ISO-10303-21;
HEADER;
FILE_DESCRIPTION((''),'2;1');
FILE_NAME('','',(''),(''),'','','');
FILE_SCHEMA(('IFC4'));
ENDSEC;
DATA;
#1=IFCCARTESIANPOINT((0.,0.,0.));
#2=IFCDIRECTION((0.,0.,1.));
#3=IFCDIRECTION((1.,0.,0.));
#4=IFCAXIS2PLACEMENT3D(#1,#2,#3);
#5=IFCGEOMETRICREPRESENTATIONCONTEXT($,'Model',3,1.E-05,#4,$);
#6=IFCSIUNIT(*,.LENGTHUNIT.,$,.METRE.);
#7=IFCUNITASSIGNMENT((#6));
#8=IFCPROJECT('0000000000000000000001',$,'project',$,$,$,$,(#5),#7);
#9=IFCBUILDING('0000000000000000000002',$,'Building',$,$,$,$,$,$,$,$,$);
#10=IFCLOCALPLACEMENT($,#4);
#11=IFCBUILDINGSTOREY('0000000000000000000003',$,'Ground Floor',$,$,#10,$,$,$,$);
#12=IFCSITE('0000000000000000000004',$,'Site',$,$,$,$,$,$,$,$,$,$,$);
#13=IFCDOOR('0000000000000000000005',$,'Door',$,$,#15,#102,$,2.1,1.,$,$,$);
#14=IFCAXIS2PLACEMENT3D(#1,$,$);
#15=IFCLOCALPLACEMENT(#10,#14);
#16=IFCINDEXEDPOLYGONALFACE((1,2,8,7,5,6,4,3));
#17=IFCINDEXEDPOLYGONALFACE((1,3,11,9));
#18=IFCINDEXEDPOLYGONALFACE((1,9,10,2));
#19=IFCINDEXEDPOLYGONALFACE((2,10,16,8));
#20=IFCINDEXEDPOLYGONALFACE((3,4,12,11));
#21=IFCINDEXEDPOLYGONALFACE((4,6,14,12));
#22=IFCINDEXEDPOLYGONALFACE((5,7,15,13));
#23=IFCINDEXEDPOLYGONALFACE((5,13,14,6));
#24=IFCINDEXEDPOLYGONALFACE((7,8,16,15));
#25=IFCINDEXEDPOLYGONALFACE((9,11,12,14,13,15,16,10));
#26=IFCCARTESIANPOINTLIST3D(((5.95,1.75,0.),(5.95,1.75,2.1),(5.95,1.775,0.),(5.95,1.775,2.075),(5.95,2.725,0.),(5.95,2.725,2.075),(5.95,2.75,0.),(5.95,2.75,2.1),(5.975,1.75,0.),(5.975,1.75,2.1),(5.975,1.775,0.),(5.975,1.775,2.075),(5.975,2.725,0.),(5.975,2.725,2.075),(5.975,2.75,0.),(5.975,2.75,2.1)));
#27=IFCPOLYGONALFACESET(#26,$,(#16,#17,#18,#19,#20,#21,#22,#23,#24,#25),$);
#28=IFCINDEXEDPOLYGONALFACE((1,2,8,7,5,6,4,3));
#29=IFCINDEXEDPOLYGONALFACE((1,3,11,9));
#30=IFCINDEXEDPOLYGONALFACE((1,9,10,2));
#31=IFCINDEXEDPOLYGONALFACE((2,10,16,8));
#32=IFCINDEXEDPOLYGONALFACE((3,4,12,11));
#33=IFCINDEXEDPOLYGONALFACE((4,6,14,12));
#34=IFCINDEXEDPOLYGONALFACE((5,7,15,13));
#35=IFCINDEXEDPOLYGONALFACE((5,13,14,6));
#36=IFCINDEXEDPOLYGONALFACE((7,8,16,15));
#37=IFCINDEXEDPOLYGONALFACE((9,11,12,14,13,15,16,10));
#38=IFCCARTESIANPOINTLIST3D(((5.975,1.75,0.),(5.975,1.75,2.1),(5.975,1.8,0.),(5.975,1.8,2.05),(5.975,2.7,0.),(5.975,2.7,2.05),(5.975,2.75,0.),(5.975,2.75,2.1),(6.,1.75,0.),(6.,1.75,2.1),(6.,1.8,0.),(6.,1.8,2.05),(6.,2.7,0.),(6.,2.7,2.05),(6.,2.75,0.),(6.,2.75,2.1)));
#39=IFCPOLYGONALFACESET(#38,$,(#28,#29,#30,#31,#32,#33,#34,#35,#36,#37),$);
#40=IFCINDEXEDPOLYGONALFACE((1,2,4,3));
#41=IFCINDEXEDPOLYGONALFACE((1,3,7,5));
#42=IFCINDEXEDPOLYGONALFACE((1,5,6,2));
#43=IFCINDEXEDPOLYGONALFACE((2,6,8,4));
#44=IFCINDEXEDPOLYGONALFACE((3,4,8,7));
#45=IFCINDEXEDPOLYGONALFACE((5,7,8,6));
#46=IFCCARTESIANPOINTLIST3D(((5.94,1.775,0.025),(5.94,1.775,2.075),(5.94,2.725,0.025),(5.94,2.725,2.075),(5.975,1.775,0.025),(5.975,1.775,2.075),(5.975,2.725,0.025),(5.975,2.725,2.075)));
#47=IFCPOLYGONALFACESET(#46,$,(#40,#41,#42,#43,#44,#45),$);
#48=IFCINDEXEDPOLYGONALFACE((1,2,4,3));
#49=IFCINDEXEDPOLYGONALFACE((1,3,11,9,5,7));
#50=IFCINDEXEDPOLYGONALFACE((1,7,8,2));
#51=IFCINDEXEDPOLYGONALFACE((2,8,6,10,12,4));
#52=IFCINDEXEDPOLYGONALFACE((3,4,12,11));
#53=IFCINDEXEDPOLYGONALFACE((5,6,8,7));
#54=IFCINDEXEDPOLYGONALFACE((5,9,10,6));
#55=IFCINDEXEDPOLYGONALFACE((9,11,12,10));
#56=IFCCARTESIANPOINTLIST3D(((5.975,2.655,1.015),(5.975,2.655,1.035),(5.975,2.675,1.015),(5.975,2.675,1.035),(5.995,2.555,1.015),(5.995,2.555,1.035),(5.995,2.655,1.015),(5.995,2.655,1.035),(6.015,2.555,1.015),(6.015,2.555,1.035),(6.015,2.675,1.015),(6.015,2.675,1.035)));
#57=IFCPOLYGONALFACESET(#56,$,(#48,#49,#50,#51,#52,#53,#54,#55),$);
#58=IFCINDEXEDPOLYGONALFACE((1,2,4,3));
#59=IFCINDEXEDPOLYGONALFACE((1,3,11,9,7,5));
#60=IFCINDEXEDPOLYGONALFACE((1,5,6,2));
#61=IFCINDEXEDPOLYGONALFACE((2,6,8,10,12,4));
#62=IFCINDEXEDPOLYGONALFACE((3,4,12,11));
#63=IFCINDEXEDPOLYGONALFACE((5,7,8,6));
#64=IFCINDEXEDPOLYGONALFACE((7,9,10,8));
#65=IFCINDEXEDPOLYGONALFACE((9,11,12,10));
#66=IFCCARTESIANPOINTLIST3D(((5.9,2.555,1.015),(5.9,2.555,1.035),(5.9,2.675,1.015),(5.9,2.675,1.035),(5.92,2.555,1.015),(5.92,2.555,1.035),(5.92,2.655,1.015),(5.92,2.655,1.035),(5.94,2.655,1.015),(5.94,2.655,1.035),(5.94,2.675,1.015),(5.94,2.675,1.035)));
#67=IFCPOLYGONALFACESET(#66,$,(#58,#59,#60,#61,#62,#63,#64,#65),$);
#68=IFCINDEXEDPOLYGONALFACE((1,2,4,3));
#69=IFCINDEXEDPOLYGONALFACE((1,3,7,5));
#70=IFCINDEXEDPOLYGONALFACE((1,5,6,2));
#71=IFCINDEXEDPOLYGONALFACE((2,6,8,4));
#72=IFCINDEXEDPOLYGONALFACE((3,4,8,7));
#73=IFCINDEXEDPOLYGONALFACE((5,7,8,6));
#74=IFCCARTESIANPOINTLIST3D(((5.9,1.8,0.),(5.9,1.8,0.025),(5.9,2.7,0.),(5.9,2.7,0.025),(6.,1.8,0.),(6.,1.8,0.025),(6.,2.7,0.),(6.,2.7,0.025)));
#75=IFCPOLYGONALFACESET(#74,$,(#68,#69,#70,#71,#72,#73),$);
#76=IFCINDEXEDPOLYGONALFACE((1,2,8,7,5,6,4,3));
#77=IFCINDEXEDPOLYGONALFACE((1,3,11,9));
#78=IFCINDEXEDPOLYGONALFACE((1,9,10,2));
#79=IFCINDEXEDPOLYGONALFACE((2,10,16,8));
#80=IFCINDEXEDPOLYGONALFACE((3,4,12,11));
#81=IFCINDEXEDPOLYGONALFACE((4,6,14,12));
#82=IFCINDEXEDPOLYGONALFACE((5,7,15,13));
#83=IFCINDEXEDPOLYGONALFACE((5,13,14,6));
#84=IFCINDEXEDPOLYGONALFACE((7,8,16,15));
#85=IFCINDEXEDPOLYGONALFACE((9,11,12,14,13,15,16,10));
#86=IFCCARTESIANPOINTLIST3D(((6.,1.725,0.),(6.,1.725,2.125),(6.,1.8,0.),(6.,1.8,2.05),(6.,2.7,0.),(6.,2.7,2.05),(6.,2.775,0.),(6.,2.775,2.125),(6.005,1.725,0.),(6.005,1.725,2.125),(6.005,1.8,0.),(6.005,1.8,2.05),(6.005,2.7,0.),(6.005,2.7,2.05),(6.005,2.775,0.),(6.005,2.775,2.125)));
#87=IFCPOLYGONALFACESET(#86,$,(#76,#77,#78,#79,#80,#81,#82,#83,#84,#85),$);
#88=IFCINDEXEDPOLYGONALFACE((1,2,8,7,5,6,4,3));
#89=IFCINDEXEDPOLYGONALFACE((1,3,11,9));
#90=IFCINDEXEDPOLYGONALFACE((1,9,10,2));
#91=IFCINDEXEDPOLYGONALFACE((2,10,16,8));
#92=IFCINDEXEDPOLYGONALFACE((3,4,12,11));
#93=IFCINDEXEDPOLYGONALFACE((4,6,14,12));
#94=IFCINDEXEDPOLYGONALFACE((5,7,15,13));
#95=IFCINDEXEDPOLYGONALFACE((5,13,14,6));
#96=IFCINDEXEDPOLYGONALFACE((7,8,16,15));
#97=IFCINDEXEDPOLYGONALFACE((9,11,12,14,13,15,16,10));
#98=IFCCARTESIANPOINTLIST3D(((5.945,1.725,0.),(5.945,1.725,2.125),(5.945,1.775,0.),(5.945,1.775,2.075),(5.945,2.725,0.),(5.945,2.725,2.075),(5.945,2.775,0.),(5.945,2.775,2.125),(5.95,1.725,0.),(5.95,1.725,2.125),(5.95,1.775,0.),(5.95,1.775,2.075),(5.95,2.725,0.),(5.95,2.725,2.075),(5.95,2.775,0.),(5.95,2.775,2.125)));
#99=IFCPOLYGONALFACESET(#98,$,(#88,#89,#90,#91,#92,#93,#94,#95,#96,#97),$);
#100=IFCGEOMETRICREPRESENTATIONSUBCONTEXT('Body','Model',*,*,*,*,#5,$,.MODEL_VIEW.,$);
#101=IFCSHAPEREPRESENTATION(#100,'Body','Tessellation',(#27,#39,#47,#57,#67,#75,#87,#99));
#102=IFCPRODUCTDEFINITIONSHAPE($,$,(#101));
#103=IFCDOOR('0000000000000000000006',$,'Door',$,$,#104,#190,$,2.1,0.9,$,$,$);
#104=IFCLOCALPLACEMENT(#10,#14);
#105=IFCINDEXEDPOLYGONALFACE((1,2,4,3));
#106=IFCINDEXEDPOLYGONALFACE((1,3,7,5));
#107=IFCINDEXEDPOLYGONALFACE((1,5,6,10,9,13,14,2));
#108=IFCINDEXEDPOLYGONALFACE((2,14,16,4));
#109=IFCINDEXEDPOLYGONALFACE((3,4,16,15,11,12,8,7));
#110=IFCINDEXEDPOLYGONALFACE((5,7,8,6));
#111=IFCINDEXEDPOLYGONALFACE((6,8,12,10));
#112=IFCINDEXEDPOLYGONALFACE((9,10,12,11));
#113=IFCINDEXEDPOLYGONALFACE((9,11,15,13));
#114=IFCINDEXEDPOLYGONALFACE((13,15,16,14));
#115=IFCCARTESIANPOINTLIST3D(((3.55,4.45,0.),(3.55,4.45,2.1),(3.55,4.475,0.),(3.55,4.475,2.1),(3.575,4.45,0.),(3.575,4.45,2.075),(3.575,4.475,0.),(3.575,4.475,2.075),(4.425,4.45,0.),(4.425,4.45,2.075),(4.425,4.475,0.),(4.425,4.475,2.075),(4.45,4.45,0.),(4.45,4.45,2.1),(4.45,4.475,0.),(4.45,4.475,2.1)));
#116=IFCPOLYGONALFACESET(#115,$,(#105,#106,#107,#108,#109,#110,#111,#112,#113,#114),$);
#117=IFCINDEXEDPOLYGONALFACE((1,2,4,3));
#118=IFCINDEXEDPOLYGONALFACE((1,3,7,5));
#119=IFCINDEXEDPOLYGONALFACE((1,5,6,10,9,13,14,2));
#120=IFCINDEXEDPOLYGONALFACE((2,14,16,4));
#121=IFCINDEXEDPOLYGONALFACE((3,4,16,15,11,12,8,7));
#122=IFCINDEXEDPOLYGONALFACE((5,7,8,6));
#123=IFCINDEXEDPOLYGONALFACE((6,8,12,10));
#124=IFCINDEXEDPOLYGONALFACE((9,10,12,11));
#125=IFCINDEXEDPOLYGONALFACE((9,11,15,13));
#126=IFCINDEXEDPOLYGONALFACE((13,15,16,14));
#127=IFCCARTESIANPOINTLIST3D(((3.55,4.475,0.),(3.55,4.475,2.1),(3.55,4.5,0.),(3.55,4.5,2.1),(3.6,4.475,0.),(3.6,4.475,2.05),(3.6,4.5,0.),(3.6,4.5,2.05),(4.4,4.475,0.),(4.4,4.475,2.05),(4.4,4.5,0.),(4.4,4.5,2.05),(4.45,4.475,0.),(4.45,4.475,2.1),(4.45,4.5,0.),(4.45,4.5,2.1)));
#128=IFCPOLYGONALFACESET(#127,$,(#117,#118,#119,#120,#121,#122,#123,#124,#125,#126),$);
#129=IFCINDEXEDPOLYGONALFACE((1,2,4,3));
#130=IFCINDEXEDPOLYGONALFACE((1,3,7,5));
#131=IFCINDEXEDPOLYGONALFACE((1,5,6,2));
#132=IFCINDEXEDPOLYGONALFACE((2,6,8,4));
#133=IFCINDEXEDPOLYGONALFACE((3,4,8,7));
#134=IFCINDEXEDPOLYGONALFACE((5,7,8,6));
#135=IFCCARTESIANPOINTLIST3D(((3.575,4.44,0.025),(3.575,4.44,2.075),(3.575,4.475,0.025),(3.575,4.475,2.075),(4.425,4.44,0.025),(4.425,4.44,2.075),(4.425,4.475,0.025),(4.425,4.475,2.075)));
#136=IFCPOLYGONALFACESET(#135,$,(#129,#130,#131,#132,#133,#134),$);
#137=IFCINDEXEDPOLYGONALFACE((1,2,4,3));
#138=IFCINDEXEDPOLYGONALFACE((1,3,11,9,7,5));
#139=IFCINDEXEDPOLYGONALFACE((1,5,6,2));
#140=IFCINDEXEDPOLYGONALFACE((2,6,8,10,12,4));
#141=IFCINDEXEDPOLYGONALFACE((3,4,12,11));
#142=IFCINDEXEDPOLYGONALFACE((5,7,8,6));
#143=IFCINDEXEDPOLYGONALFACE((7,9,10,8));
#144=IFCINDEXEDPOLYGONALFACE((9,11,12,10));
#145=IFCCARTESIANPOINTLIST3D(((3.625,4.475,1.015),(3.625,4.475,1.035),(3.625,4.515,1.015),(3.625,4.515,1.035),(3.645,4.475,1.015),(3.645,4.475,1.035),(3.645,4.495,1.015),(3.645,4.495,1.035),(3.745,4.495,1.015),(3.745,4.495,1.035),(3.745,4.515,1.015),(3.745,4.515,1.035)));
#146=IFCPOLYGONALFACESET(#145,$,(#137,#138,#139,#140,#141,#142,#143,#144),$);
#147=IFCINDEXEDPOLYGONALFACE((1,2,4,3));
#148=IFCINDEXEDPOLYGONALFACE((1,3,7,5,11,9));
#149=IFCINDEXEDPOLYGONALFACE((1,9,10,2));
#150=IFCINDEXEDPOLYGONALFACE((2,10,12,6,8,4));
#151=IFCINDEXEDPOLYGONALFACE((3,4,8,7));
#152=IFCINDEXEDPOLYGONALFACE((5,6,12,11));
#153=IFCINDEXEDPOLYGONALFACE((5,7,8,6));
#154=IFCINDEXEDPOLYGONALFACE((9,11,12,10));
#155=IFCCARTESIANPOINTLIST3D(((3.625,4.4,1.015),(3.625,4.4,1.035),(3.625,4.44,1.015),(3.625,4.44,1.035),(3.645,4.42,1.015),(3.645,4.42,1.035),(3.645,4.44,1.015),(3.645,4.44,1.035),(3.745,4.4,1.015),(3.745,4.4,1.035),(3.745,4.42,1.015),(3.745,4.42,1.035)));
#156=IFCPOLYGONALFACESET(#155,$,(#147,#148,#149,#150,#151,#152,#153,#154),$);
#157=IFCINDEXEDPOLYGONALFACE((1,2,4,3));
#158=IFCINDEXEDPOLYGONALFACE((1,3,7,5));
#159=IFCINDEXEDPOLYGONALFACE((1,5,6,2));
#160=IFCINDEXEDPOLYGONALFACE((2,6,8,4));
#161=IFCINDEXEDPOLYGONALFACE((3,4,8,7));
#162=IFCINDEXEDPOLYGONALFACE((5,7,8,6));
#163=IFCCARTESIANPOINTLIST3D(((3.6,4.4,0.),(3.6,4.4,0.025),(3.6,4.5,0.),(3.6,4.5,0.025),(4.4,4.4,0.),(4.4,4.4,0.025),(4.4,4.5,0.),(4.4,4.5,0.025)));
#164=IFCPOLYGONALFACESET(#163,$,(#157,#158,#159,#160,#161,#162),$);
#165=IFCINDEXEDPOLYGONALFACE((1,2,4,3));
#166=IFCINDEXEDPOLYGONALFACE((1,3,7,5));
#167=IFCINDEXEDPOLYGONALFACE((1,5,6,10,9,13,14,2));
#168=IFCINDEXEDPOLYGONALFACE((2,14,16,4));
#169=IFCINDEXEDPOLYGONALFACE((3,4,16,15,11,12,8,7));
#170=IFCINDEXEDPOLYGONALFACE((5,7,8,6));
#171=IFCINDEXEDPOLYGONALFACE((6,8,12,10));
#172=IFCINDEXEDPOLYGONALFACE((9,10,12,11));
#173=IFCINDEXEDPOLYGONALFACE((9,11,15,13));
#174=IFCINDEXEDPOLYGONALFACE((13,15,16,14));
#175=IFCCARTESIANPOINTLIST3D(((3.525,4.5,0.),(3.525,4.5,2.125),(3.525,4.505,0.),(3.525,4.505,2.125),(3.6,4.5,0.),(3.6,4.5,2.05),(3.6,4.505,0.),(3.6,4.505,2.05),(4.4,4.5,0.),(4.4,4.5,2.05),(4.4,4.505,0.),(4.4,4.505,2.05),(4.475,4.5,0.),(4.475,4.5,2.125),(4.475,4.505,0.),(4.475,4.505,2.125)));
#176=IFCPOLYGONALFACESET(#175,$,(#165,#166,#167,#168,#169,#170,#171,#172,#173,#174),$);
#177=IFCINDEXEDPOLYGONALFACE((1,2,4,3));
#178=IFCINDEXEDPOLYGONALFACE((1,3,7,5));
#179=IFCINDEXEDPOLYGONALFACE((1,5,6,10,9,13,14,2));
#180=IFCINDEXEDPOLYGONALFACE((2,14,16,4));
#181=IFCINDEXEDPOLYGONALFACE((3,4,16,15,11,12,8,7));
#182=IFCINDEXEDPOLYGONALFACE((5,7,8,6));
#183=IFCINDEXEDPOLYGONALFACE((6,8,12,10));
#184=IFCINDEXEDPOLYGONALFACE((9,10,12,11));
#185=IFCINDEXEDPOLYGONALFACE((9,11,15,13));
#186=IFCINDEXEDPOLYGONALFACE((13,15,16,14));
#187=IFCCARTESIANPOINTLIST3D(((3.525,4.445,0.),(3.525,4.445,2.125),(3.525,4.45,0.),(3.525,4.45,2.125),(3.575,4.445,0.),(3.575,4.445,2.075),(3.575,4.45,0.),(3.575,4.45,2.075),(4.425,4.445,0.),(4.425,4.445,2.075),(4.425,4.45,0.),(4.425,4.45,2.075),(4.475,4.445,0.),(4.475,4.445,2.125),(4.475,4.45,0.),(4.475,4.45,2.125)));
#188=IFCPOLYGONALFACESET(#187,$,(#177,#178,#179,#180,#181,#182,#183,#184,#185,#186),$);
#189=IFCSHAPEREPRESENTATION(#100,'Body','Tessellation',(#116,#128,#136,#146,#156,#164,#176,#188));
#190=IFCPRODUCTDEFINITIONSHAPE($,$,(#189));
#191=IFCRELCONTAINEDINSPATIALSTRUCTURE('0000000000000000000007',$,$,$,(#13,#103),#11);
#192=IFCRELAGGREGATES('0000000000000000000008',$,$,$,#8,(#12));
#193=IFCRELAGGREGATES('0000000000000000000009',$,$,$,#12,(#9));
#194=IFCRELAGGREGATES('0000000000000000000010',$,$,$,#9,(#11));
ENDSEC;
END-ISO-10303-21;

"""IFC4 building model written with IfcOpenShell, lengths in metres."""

from ifc_helpers import new_model, si_unit, frame, origin_with_axes, place, context, subcontext, project, spatial, line, indexed_curve, outline, extrude, element, save


model = new_model("IFC4")

# Units and contexts
model_context = context("Model", 3, precision=1e-05, world=origin_with_axes())
body_context = subcontext(model_context, "Body", "Model", "MODEL_VIEW")
ifc_project = project(units=[si_unit("LENGTHUNIT", "METRE")], contexts=[model_context])

# Site, building, storey
site = spatial("IfcSite", under=ifc_project, Name="Site")
building = spatial("IfcBuilding", under=site, Name="Building")
storey_placement = place(None, origin_with_axes())
storey = spatial("IfcBuildingStorey", under=building, at=storey_placement, Name="Ground Floor")

# Doors
door_1_placement = place(storey_placement, frame((6.0, 1.75, 0.0), z_axis=(0.0, 0.0, 1.0), x_axis=(0.0, 1.0, 0.0)))
element("IfcDoor", 1, at=door_1_placement, inside=storey, Name="Door", OverallHeight=2.1, OverallWidth=1.0, context=body_context, shape_type="SweptSolid", body=[
    extrude(outline(indexed_curve([(0.0, 0.0), (0.0, 2.1), (1.0, 2.1), (1.0, 0.0), (0.975, 0.0), (0.975, 2.075), (0.025, 2.075), (0.025, 0.0)], segments=[line(1, 2, 3, 4, 5, 6, 7, 8, 1)])), frame((0.0, 0.025, 0.0), z_axis=(0.0, -1.0, 0.0), x_axis=(1.0, 0.0, 0.0)), (0.0, 0.0, -1.0), 0.025),
    extrude(outline(indexed_curve([(0.0, 0.0), (0.0, 2.1), (1.0, 2.1), (1.0, 0.0), (0.95, 0.0), (0.95, 2.05), (0.05, 2.05), (0.05, 0.0)], segments=[line(1, 2, 3, 4, 5, 6, 7, 8, 1)])), frame((0.0, 0.0, 0.0), z_axis=(0.0, -1.0, 0.0), x_axis=(1.0, 0.0, 0.0)), (0.0, 0.0, -1.0), 0.025),
    extrude(outline(indexed_curve([(0.0, 0.0), (0.95, 0.0), (0.95, 0.035), (0.0, 0.035)], segments=[line(1, 2, 3, 4, 1)])), frame((0.025, 0.025, 0.025), z_axis=(0.0, 0.0, 1.0), x_axis=(1.0, 0.0, 0.0)), (0.0, 0.0, 1.0), 2.05),
    extrude(outline(indexed_curve([(0.0, 0.0), (0.0, -0.04), (-0.12, -0.04), (-0.12, -0.02), (-0.02, -0.02), (-0.02, 0.0)], segments=[line(1, 2, 3, 4, 5, 6, 1)])), frame((0.925, 0.025, 1.015), z_axis=(0.0, 0.0, 1.0), x_axis=(1.0, 0.0, 0.0)), (0.0, 0.0, 1.0), 0.02),
    extrude(outline(indexed_curve([(0.0, 0.0), (0.0, 0.04), (-0.12, 0.04), (-0.12, 0.02), (-0.02, 0.02), (-0.02, 0.0)], segments=[line(1, 2, 3, 4, 5, 6, 1)])), frame((0.925, 0.06, 1.015), z_axis=(0.0, 0.0, 1.0), x_axis=(1.0, 0.0, 0.0)), (0.0, 0.0, 1.0), 0.02),
    extrude(outline(indexed_curve([(0.0, 0.0), (0.9, 0.0), (0.9, 0.1), (0.0, 0.1)], segments=[line(1, 2, 3, 4, 1)])), frame((0.05, 0.0, 0.0), z_axis=(0.0, 0.0, 1.0), x_axis=(1.0, 0.0, 0.0)), (0.0, 0.0, 1.0), 0.025),
    extrude(outline(indexed_curve([(0.0, 0.0), (0.0, 2.125), (1.05, 2.125), (1.05, 0.0), (0.975, 0.0), (0.975, 2.05), (0.075, 2.05), (0.075, 0.0)], segments=[line(1, 2, 3, 4, 5, 6, 7, 8, 1)])), frame((-0.025, -0.005, 0.0), z_axis=(0.0, -1.0, 0.0), x_axis=(1.0, 0.0, 0.0)), (0.0, 0.0, -1.0), 0.005),
    extrude(outline(indexed_curve([(0.0, 0.0), (0.0, 2.125), (1.05, 2.125), (1.05, 0.0), (1.0, 0.0), (1.0, 2.075), (0.05, 2.075), (0.05, 0.0)], segments=[line(1, 2, 3, 4, 5, 6, 7, 8, 1)])), frame((-0.025, 0.05, 0.0), z_axis=(0.0, -1.0, 0.0), x_axis=(1.0, 0.0, 0.0)), (0.0, 0.0, -1.0), 0.005),
])
door_2_placement = place(storey_placement, frame((4.45, 4.5, 0.0), z_axis=(0.0, 0.0, 1.0), x_axis=(-1.0, 0.0, 0.0)))
element("IfcDoor", 2, at=door_2_placement, inside=storey, Name="Door", OverallHeight=2.1, OverallWidth=0.9, context=body_context, shape_type="SweptSolid", body=[
    extrude(outline(indexed_curve([(0.0, 0.0), (0.0, 2.1), (0.9, 2.1), (0.9, 0.0), (0.875, 0.0), (0.875, 2.075), (0.025, 2.075), (0.025, 0.0)], segments=[line(1, 2, 3, 4, 5, 6, 7, 8, 1)])), frame((0.0, 0.025, 0.0), z_axis=(0.0, -1.0, 0.0), x_axis=(1.0, 0.0, 0.0)), (0.0, 0.0, -1.0), 0.025),
    extrude(outline(indexed_curve([(0.0, 0.0), (0.0, 2.1), (0.9, 2.1), (0.9, 0.0), (0.85, 0.0), (0.85, 2.05), (0.05, 2.05), (0.05, 0.0)], segments=[line(1, 2, 3, 4, 5, 6, 7, 8, 1)])), frame((0.0, 0.0, 0.0), z_axis=(0.0, -1.0, 0.0), x_axis=(1.0, 0.0, 0.0)), (0.0, 0.0, -1.0), 0.025),
    extrude(outline(indexed_curve([(0.0, 0.0), (0.85, 0.0), (0.85, 0.035), (0.0, 0.035)], segments=[line(1, 2, 3, 4, 1)])), frame((0.025, 0.025, 0.025), z_axis=(0.0, 0.0, 1.0), x_axis=(1.0, 0.0, 0.0)), (0.0, 0.0, 1.0), 2.05),
    extrude(outline(indexed_curve([(0.0, 0.0), (0.0, -0.04), (-0.12, -0.04), (-0.12, -0.02), (-0.02, -0.02), (-0.02, 0.0)], segments=[line(1, 2, 3, 4, 5, 6, 1)])), frame((0.825, 0.025, 1.015), z_axis=(0.0, 0.0, 1.0), x_axis=(1.0, 0.0, 0.0)), (0.0, 0.0, 1.0), 0.02),
    extrude(outline(indexed_curve([(0.0, 0.0), (0.0, 0.04), (-0.12, 0.04), (-0.12, 0.02), (-0.02, 0.02), (-0.02, 0.0)], segments=[line(1, 2, 3, 4, 5, 6, 1)])), frame((0.825, 0.06, 1.015), z_axis=(0.0, 0.0, 1.0), x_axis=(1.0, 0.0, 0.0)), (0.0, 0.0, 1.0), 0.02),
    extrude(outline(indexed_curve([(0.0, 0.0), (0.8, 0.0), (0.8, 0.1), (0.0, 0.1)], segments=[line(1, 2, 3, 4, 1)])), frame((0.05, 0.0, 0.0), z_axis=(0.0, 0.0, 1.0), x_axis=(1.0, 0.0, 0.0)), (0.0, 0.0, 1.0), 0.025),
    extrude(outline(indexed_curve([(0.0, 0.0), (0.0, 2.125), (0.95, 2.125), (0.95, 0.0), (0.875, 0.0), (0.875, 2.05), (0.075, 2.05), (0.075, 0.0)], segments=[line(1, 2, 3, 4, 5, 6, 7, 8, 1)])), frame((-0.025, -0.005, 0.0), z_axis=(0.0, -1.0, 0.0), x_axis=(1.0, 0.0, 0.0)), (0.0, 0.0, -1.0), 0.005),
    extrude(outline(indexed_curve([(0.0, 0.0), (0.0, 2.125), (0.95, 2.125), (0.95, 0.0), (0.9, 0.0), (0.9, 2.075), (0.05, 2.075), (0.05, 0.0)], segments=[line(1, 2, 3, 4, 5, 6, 7, 8, 1)])), frame((-0.025, 0.05, 0.0), z_axis=(0.0, -1.0, 0.0), x_axis=(1.0, 0.0, 0.0)), (0.0, 0.0, -1.0), 0.005),
])

save(model, "model.ifc")
